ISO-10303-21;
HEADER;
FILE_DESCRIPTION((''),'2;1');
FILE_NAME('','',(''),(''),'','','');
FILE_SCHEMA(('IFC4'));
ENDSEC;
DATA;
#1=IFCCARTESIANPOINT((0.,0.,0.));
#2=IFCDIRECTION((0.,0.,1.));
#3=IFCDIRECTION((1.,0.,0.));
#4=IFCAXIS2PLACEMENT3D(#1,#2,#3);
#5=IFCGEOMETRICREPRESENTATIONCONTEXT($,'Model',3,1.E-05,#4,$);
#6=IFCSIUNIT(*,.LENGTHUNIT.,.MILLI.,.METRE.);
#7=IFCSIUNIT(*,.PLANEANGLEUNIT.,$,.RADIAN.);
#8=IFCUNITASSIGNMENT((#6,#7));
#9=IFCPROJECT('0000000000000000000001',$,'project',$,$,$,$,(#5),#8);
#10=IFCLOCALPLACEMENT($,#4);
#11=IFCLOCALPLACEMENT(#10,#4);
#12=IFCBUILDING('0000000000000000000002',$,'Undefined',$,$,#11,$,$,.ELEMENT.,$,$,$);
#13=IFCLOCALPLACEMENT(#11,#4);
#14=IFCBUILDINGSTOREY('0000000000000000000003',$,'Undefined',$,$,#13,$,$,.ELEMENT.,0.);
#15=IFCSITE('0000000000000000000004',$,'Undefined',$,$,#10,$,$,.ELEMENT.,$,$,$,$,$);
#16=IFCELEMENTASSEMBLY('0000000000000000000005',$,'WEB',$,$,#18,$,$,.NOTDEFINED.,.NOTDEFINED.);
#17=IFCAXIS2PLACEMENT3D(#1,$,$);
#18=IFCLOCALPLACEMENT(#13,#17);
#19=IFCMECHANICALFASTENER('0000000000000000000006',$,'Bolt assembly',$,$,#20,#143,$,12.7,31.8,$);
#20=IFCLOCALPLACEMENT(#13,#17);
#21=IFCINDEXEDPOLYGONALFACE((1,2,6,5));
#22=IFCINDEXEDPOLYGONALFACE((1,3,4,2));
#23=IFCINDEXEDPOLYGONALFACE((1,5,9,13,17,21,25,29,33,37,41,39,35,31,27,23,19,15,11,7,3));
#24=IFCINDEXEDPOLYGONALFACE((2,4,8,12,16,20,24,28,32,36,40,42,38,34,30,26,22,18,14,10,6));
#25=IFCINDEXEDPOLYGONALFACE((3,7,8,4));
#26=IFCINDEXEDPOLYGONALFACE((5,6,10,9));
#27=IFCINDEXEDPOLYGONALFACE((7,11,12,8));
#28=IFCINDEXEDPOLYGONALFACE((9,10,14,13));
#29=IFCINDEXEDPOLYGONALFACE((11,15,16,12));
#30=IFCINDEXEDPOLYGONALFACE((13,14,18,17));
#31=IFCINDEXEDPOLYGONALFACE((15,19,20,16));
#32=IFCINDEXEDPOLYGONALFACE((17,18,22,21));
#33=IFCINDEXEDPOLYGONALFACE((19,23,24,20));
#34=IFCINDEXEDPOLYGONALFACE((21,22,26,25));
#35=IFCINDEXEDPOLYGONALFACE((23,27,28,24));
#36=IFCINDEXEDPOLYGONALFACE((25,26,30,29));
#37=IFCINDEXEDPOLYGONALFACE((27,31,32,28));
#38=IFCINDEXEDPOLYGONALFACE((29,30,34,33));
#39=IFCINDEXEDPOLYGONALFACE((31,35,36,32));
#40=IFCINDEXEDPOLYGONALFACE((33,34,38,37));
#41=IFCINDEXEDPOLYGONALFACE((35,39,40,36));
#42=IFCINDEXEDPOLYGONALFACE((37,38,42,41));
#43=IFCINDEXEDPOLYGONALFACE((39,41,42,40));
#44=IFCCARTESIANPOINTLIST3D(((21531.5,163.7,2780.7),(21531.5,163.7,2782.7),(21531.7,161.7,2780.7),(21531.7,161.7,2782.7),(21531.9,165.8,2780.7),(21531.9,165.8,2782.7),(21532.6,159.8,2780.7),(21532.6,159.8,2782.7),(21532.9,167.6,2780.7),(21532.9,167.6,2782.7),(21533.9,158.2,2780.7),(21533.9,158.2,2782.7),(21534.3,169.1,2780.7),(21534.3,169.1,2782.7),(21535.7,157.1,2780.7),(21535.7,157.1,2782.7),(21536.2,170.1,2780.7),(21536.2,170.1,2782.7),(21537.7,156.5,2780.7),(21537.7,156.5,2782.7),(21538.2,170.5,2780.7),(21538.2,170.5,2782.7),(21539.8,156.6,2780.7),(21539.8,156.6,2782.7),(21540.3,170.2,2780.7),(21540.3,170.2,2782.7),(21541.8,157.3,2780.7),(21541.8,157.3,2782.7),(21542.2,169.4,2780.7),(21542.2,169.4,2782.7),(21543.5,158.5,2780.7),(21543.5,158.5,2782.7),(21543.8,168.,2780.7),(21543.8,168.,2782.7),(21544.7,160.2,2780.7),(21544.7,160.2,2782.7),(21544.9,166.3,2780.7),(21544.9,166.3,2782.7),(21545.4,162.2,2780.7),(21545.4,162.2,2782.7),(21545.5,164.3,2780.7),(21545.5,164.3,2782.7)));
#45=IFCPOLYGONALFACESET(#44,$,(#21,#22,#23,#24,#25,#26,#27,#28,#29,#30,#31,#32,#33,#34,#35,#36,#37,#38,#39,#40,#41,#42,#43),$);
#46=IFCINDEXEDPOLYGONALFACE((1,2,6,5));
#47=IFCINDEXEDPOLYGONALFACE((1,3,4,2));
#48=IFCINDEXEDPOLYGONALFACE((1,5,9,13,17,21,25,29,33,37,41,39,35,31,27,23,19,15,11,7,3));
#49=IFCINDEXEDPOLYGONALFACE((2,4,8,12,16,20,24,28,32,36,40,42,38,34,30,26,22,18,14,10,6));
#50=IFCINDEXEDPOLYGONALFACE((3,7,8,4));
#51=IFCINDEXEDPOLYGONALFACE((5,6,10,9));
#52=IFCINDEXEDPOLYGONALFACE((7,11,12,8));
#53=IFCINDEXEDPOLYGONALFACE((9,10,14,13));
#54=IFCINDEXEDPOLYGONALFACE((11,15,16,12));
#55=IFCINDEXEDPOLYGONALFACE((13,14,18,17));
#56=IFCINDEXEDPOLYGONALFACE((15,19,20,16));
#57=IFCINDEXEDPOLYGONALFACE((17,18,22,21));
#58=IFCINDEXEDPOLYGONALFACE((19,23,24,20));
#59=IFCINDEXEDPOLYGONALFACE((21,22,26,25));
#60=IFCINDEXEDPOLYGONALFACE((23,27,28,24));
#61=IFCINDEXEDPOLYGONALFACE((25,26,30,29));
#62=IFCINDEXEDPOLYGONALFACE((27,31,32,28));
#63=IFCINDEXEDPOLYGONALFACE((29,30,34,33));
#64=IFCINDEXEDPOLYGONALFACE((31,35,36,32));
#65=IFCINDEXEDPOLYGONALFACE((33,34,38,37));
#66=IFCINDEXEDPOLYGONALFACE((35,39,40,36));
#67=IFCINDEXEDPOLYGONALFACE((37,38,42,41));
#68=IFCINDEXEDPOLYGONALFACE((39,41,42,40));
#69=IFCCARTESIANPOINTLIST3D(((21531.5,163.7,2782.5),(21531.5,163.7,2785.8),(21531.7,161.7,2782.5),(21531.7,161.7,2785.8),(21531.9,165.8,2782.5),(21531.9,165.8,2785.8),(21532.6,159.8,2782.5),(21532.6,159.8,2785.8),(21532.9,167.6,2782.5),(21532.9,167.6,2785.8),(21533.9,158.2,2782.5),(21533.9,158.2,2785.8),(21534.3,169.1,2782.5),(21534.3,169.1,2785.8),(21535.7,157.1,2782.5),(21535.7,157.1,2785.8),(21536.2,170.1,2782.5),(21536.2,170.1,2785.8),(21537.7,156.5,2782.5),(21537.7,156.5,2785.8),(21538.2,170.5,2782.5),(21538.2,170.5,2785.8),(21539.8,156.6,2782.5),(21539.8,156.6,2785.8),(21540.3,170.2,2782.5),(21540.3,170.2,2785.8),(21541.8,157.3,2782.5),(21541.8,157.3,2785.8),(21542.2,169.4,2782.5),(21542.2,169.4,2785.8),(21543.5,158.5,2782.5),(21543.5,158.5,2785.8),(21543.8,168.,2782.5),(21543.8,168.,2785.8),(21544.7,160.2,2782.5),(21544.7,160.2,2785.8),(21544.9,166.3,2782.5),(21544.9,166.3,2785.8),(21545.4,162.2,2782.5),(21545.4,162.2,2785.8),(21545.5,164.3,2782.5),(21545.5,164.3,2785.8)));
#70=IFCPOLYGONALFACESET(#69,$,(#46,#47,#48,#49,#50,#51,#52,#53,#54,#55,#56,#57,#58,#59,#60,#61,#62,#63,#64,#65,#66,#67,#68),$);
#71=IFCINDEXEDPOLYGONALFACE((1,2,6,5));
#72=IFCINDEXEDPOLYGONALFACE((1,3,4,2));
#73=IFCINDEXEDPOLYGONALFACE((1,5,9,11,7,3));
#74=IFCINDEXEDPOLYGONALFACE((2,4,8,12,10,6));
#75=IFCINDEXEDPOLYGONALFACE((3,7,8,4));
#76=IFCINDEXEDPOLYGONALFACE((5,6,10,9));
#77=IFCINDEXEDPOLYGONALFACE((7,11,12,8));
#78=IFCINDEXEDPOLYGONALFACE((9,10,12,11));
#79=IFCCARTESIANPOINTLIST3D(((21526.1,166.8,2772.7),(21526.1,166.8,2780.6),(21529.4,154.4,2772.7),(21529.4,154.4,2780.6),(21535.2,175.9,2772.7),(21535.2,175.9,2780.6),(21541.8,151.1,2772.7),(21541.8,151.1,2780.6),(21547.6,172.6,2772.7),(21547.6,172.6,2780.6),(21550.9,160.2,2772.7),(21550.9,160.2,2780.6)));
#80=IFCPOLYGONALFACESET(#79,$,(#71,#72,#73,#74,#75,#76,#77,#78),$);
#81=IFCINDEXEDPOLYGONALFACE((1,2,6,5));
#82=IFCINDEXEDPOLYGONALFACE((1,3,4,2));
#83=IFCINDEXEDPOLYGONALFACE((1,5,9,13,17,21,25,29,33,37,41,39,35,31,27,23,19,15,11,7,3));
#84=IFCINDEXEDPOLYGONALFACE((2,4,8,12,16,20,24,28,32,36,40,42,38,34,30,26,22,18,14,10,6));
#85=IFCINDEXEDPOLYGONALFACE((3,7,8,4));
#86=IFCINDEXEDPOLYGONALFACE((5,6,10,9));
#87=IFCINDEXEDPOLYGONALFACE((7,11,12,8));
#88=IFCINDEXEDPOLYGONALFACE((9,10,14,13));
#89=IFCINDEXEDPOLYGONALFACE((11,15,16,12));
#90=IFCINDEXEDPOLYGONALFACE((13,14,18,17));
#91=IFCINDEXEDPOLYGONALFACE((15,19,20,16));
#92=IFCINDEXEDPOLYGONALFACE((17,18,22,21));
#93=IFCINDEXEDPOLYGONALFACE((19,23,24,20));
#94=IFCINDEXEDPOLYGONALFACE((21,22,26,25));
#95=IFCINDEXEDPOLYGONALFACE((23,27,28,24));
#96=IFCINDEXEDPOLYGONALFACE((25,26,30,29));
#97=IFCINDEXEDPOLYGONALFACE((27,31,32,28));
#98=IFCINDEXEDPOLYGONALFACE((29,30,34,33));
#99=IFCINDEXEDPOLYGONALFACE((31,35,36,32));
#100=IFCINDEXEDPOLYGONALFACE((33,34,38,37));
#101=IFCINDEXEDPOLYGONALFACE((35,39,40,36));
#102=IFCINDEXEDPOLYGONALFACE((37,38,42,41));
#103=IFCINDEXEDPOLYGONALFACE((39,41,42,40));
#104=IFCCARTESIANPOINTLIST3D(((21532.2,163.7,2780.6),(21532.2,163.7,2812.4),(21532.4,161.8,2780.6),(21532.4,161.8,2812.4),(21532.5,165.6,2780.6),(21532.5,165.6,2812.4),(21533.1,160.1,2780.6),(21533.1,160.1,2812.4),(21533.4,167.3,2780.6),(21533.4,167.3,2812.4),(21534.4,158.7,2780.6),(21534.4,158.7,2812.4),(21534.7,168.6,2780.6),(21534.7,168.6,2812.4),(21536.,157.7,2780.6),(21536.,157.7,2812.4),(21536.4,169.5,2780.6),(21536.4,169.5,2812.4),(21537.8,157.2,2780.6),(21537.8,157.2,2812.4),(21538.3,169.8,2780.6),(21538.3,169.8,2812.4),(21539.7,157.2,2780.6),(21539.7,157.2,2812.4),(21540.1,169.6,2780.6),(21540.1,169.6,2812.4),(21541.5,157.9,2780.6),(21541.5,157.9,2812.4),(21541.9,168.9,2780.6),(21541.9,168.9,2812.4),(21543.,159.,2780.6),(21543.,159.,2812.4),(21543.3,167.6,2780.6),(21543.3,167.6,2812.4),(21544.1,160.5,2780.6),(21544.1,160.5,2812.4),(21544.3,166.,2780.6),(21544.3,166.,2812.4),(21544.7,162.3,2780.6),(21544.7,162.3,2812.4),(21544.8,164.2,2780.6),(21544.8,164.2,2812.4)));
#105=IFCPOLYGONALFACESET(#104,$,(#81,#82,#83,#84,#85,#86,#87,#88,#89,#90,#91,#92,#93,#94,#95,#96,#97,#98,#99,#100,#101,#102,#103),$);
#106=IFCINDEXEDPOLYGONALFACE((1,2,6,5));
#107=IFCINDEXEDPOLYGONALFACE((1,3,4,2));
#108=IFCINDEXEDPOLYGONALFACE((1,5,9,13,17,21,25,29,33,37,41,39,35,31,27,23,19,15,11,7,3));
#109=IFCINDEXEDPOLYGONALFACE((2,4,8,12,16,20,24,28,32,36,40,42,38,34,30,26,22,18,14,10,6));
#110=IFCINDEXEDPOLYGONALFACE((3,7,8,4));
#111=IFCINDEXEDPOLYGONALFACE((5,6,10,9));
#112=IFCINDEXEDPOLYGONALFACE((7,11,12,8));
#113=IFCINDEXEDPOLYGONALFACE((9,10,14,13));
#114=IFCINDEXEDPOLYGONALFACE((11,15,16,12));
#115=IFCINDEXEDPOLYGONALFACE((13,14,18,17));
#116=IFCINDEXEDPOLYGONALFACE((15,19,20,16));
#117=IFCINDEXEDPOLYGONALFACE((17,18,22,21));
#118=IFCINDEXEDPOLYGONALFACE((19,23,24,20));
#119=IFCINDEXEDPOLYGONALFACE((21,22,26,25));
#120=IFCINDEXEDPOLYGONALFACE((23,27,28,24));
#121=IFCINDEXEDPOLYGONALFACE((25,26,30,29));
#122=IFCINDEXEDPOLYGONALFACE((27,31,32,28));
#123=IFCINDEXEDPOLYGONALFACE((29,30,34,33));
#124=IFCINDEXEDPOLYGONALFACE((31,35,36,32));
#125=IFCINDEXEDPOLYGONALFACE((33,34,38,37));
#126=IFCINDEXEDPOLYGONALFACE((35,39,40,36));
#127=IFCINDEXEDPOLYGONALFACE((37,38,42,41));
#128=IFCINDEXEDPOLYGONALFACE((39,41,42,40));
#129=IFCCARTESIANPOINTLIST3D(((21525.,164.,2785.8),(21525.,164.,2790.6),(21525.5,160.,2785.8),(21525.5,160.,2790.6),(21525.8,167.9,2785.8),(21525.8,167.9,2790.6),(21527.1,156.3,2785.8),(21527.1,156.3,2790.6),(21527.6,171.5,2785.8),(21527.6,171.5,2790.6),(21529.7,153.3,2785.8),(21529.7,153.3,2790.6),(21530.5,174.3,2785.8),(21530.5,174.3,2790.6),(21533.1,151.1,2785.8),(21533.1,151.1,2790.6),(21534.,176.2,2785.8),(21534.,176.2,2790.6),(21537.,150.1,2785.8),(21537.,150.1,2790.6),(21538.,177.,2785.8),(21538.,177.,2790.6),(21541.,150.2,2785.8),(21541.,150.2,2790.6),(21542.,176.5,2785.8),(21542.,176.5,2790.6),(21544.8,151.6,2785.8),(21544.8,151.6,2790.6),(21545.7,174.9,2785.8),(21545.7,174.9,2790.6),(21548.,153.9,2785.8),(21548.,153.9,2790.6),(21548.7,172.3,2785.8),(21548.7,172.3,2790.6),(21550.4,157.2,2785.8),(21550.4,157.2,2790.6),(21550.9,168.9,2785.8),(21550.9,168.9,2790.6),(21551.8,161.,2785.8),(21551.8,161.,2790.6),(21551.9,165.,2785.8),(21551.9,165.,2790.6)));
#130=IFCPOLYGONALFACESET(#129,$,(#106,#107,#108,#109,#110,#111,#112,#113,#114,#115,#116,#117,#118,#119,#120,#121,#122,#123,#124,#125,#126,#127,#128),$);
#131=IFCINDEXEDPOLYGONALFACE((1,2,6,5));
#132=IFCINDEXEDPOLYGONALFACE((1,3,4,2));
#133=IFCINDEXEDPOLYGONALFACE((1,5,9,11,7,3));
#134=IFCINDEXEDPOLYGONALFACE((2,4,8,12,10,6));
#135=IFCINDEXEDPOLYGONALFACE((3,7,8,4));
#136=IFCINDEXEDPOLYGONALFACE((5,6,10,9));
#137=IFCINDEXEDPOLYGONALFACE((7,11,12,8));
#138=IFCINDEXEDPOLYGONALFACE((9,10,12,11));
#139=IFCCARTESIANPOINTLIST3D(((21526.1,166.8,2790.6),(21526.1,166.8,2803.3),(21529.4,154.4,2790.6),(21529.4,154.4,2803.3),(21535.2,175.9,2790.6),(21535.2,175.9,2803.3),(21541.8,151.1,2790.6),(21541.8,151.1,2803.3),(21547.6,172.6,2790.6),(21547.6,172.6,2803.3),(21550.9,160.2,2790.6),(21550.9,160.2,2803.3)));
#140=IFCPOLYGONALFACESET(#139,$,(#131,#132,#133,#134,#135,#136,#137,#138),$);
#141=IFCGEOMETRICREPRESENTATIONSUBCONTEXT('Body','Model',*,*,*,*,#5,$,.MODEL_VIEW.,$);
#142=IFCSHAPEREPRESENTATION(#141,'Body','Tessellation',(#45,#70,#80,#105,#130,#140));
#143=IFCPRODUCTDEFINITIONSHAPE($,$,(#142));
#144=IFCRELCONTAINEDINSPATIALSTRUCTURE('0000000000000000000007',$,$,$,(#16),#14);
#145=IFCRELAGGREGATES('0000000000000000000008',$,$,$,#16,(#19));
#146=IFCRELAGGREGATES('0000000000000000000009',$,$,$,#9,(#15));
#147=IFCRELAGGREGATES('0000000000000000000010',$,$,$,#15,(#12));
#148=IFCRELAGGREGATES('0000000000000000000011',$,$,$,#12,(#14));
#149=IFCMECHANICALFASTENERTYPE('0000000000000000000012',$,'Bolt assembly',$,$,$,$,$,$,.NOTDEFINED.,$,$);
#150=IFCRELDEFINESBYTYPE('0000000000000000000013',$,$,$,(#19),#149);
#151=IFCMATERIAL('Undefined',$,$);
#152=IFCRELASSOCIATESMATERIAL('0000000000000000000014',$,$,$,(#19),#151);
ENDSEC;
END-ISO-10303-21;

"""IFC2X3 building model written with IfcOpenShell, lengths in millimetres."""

from ifc_helpers import new_model, si_unit, frame, origin_with_axes, origin_2d_with_axis, place, context, subcontext, project, spatial, polyline, circle, outline, extrude, source, transform, mapped, material, type_object, element, aggregate, save


model = new_model("IFC2X3")

# Units and contexts
model_context = context("Model", 3, precision=1e-05, world=origin_with_axes())
body_context = subcontext(model_context, "Body", "Model", "MODEL_VIEW")
ifc_project = project(units=[si_unit("LENGTHUNIT", "METRE", prefix="MILLI"), si_unit("PLANEANGLEUNIT", "RADIAN")], contexts=[model_context])

# Site, building, storey
site_placement = place(None, origin_with_axes())
site = spatial("IfcSite", under=ifc_project, at=site_placement, Name="Undefined", CompositionType="ELEMENT")
building_placement = place(site_placement, origin_with_axes())
building = spatial("IfcBuilding", under=site, at=building_placement, Name="Undefined", CompositionType="ELEMENT")
storey_placement = place(building_placement, origin_with_axes())
storey = spatial("IfcBuildingStorey", under=building, at=storey_placement, Name="Undefined", CompositionType="ELEMENT", Elevation=0.0)

# Element assembly
assembly_1_placement = place(storey_placement, origin_with_axes())
assembly_1 = element("IfcElementAssembly", 1, at=assembly_1_placement, inside=storey, Name="WEB", AssemblyPlace="NOTDEFINED", PredefinedType="NOTDEFINED")

# Shared definitions
ifc_material_1 = material(Name="Undefined")
mechanical_fastener_type = type_object("IfcMechanicalFastenerType", Name="Bolt assembly")

# Mechanical fastener
shared_shape_1 = source(origin_with_axes(), body_context, "Body", "SweptSolid", [
    extrude(circle(Radius=7.0, at=origin_2d_with_axis()), frame((0.0, -1.9, 0.0), z_axis=(0.0, 1.0, 0.0), x_axis=(1.0, 0.0, 0.0)), (0.0, 0.0, 1.0), 2.0),
    extrude(circle(Radius=7.0, at=origin_2d_with_axis()), frame((0.0, -0.1, 0.0), z_axis=(0.0, 1.0, 0.0), x_axis=(1.0, 0.0, 0.0)), (0.0, 0.0, 1.0), 3.3),
    extrude(outline(polyline([(11.1, -6.4), (11.1, 6.4), (0.0, 12.8), (-11.1, 6.4), (-11.1, -6.4), (0.0, -12.8), (11.1, -6.4)])), frame((0.0, -9.9, 0.0), z_axis=(0.0, 1.0, 0.0), x_axis=(1.0, 0.0, 0.0)), (0.0, 0.0, 1.0), 7.9),
    extrude(circle(Radius=6.3, at=origin_2d_with_axis()), frame((0.0, -2.0, 0.0), z_axis=(0.0, 1.0, 0.0), x_axis=(1.0, 0.0, 0.0)), (0.0, 0.0, 1.0), 31.8),
    extrude(circle(Radius=13.5, at=origin_2d_with_axis()), frame((0.0, 3.2, 0.0), z_axis=(0.0, 1.0, 0.0), x_axis=(1.0, 0.0, 0.0)), (0.0, 0.0, 1.0), 4.8),
    extrude(outline(polyline([(11.1, -6.4), (11.1, 6.4), (0.0, 12.8), (-11.1, 6.4), (-11.1, -6.4), (0.0, -12.8), (11.1, -6.4)])), frame((0.0, 8.0, 0.0), z_axis=(0.0, 1.0, 0.0), x_axis=(1.0, 0.0, 0.0)), (0.0, 0.0, 1.0), 12.7),
])
mechanical_fastener_1_placement = place(assembly_1_placement, frame((21538.5, 163.5, 2782.6), z_axis=(-0.707106, -0.707107, 0.000005), x_axis=(0.707107, -0.707107, 0.000005)))
mechanical_fastener_1 = element("IfcMechanicalFastener", 2, at=mechanical_fastener_1_placement, type_object=mechanical_fastener_type, material=ifc_material_1, Name="Bolt assembly", NominalDiameter=12.7, NominalLength=31.8, context=body_context, shape_type="MappedRepresentation", body=[
    mapped(shared_shape_1, transform((0.0, 0.0, 0.0))),
])
aggregate(assembly_1, [mechanical_fastener_1])

save(model, "model.ifc")
